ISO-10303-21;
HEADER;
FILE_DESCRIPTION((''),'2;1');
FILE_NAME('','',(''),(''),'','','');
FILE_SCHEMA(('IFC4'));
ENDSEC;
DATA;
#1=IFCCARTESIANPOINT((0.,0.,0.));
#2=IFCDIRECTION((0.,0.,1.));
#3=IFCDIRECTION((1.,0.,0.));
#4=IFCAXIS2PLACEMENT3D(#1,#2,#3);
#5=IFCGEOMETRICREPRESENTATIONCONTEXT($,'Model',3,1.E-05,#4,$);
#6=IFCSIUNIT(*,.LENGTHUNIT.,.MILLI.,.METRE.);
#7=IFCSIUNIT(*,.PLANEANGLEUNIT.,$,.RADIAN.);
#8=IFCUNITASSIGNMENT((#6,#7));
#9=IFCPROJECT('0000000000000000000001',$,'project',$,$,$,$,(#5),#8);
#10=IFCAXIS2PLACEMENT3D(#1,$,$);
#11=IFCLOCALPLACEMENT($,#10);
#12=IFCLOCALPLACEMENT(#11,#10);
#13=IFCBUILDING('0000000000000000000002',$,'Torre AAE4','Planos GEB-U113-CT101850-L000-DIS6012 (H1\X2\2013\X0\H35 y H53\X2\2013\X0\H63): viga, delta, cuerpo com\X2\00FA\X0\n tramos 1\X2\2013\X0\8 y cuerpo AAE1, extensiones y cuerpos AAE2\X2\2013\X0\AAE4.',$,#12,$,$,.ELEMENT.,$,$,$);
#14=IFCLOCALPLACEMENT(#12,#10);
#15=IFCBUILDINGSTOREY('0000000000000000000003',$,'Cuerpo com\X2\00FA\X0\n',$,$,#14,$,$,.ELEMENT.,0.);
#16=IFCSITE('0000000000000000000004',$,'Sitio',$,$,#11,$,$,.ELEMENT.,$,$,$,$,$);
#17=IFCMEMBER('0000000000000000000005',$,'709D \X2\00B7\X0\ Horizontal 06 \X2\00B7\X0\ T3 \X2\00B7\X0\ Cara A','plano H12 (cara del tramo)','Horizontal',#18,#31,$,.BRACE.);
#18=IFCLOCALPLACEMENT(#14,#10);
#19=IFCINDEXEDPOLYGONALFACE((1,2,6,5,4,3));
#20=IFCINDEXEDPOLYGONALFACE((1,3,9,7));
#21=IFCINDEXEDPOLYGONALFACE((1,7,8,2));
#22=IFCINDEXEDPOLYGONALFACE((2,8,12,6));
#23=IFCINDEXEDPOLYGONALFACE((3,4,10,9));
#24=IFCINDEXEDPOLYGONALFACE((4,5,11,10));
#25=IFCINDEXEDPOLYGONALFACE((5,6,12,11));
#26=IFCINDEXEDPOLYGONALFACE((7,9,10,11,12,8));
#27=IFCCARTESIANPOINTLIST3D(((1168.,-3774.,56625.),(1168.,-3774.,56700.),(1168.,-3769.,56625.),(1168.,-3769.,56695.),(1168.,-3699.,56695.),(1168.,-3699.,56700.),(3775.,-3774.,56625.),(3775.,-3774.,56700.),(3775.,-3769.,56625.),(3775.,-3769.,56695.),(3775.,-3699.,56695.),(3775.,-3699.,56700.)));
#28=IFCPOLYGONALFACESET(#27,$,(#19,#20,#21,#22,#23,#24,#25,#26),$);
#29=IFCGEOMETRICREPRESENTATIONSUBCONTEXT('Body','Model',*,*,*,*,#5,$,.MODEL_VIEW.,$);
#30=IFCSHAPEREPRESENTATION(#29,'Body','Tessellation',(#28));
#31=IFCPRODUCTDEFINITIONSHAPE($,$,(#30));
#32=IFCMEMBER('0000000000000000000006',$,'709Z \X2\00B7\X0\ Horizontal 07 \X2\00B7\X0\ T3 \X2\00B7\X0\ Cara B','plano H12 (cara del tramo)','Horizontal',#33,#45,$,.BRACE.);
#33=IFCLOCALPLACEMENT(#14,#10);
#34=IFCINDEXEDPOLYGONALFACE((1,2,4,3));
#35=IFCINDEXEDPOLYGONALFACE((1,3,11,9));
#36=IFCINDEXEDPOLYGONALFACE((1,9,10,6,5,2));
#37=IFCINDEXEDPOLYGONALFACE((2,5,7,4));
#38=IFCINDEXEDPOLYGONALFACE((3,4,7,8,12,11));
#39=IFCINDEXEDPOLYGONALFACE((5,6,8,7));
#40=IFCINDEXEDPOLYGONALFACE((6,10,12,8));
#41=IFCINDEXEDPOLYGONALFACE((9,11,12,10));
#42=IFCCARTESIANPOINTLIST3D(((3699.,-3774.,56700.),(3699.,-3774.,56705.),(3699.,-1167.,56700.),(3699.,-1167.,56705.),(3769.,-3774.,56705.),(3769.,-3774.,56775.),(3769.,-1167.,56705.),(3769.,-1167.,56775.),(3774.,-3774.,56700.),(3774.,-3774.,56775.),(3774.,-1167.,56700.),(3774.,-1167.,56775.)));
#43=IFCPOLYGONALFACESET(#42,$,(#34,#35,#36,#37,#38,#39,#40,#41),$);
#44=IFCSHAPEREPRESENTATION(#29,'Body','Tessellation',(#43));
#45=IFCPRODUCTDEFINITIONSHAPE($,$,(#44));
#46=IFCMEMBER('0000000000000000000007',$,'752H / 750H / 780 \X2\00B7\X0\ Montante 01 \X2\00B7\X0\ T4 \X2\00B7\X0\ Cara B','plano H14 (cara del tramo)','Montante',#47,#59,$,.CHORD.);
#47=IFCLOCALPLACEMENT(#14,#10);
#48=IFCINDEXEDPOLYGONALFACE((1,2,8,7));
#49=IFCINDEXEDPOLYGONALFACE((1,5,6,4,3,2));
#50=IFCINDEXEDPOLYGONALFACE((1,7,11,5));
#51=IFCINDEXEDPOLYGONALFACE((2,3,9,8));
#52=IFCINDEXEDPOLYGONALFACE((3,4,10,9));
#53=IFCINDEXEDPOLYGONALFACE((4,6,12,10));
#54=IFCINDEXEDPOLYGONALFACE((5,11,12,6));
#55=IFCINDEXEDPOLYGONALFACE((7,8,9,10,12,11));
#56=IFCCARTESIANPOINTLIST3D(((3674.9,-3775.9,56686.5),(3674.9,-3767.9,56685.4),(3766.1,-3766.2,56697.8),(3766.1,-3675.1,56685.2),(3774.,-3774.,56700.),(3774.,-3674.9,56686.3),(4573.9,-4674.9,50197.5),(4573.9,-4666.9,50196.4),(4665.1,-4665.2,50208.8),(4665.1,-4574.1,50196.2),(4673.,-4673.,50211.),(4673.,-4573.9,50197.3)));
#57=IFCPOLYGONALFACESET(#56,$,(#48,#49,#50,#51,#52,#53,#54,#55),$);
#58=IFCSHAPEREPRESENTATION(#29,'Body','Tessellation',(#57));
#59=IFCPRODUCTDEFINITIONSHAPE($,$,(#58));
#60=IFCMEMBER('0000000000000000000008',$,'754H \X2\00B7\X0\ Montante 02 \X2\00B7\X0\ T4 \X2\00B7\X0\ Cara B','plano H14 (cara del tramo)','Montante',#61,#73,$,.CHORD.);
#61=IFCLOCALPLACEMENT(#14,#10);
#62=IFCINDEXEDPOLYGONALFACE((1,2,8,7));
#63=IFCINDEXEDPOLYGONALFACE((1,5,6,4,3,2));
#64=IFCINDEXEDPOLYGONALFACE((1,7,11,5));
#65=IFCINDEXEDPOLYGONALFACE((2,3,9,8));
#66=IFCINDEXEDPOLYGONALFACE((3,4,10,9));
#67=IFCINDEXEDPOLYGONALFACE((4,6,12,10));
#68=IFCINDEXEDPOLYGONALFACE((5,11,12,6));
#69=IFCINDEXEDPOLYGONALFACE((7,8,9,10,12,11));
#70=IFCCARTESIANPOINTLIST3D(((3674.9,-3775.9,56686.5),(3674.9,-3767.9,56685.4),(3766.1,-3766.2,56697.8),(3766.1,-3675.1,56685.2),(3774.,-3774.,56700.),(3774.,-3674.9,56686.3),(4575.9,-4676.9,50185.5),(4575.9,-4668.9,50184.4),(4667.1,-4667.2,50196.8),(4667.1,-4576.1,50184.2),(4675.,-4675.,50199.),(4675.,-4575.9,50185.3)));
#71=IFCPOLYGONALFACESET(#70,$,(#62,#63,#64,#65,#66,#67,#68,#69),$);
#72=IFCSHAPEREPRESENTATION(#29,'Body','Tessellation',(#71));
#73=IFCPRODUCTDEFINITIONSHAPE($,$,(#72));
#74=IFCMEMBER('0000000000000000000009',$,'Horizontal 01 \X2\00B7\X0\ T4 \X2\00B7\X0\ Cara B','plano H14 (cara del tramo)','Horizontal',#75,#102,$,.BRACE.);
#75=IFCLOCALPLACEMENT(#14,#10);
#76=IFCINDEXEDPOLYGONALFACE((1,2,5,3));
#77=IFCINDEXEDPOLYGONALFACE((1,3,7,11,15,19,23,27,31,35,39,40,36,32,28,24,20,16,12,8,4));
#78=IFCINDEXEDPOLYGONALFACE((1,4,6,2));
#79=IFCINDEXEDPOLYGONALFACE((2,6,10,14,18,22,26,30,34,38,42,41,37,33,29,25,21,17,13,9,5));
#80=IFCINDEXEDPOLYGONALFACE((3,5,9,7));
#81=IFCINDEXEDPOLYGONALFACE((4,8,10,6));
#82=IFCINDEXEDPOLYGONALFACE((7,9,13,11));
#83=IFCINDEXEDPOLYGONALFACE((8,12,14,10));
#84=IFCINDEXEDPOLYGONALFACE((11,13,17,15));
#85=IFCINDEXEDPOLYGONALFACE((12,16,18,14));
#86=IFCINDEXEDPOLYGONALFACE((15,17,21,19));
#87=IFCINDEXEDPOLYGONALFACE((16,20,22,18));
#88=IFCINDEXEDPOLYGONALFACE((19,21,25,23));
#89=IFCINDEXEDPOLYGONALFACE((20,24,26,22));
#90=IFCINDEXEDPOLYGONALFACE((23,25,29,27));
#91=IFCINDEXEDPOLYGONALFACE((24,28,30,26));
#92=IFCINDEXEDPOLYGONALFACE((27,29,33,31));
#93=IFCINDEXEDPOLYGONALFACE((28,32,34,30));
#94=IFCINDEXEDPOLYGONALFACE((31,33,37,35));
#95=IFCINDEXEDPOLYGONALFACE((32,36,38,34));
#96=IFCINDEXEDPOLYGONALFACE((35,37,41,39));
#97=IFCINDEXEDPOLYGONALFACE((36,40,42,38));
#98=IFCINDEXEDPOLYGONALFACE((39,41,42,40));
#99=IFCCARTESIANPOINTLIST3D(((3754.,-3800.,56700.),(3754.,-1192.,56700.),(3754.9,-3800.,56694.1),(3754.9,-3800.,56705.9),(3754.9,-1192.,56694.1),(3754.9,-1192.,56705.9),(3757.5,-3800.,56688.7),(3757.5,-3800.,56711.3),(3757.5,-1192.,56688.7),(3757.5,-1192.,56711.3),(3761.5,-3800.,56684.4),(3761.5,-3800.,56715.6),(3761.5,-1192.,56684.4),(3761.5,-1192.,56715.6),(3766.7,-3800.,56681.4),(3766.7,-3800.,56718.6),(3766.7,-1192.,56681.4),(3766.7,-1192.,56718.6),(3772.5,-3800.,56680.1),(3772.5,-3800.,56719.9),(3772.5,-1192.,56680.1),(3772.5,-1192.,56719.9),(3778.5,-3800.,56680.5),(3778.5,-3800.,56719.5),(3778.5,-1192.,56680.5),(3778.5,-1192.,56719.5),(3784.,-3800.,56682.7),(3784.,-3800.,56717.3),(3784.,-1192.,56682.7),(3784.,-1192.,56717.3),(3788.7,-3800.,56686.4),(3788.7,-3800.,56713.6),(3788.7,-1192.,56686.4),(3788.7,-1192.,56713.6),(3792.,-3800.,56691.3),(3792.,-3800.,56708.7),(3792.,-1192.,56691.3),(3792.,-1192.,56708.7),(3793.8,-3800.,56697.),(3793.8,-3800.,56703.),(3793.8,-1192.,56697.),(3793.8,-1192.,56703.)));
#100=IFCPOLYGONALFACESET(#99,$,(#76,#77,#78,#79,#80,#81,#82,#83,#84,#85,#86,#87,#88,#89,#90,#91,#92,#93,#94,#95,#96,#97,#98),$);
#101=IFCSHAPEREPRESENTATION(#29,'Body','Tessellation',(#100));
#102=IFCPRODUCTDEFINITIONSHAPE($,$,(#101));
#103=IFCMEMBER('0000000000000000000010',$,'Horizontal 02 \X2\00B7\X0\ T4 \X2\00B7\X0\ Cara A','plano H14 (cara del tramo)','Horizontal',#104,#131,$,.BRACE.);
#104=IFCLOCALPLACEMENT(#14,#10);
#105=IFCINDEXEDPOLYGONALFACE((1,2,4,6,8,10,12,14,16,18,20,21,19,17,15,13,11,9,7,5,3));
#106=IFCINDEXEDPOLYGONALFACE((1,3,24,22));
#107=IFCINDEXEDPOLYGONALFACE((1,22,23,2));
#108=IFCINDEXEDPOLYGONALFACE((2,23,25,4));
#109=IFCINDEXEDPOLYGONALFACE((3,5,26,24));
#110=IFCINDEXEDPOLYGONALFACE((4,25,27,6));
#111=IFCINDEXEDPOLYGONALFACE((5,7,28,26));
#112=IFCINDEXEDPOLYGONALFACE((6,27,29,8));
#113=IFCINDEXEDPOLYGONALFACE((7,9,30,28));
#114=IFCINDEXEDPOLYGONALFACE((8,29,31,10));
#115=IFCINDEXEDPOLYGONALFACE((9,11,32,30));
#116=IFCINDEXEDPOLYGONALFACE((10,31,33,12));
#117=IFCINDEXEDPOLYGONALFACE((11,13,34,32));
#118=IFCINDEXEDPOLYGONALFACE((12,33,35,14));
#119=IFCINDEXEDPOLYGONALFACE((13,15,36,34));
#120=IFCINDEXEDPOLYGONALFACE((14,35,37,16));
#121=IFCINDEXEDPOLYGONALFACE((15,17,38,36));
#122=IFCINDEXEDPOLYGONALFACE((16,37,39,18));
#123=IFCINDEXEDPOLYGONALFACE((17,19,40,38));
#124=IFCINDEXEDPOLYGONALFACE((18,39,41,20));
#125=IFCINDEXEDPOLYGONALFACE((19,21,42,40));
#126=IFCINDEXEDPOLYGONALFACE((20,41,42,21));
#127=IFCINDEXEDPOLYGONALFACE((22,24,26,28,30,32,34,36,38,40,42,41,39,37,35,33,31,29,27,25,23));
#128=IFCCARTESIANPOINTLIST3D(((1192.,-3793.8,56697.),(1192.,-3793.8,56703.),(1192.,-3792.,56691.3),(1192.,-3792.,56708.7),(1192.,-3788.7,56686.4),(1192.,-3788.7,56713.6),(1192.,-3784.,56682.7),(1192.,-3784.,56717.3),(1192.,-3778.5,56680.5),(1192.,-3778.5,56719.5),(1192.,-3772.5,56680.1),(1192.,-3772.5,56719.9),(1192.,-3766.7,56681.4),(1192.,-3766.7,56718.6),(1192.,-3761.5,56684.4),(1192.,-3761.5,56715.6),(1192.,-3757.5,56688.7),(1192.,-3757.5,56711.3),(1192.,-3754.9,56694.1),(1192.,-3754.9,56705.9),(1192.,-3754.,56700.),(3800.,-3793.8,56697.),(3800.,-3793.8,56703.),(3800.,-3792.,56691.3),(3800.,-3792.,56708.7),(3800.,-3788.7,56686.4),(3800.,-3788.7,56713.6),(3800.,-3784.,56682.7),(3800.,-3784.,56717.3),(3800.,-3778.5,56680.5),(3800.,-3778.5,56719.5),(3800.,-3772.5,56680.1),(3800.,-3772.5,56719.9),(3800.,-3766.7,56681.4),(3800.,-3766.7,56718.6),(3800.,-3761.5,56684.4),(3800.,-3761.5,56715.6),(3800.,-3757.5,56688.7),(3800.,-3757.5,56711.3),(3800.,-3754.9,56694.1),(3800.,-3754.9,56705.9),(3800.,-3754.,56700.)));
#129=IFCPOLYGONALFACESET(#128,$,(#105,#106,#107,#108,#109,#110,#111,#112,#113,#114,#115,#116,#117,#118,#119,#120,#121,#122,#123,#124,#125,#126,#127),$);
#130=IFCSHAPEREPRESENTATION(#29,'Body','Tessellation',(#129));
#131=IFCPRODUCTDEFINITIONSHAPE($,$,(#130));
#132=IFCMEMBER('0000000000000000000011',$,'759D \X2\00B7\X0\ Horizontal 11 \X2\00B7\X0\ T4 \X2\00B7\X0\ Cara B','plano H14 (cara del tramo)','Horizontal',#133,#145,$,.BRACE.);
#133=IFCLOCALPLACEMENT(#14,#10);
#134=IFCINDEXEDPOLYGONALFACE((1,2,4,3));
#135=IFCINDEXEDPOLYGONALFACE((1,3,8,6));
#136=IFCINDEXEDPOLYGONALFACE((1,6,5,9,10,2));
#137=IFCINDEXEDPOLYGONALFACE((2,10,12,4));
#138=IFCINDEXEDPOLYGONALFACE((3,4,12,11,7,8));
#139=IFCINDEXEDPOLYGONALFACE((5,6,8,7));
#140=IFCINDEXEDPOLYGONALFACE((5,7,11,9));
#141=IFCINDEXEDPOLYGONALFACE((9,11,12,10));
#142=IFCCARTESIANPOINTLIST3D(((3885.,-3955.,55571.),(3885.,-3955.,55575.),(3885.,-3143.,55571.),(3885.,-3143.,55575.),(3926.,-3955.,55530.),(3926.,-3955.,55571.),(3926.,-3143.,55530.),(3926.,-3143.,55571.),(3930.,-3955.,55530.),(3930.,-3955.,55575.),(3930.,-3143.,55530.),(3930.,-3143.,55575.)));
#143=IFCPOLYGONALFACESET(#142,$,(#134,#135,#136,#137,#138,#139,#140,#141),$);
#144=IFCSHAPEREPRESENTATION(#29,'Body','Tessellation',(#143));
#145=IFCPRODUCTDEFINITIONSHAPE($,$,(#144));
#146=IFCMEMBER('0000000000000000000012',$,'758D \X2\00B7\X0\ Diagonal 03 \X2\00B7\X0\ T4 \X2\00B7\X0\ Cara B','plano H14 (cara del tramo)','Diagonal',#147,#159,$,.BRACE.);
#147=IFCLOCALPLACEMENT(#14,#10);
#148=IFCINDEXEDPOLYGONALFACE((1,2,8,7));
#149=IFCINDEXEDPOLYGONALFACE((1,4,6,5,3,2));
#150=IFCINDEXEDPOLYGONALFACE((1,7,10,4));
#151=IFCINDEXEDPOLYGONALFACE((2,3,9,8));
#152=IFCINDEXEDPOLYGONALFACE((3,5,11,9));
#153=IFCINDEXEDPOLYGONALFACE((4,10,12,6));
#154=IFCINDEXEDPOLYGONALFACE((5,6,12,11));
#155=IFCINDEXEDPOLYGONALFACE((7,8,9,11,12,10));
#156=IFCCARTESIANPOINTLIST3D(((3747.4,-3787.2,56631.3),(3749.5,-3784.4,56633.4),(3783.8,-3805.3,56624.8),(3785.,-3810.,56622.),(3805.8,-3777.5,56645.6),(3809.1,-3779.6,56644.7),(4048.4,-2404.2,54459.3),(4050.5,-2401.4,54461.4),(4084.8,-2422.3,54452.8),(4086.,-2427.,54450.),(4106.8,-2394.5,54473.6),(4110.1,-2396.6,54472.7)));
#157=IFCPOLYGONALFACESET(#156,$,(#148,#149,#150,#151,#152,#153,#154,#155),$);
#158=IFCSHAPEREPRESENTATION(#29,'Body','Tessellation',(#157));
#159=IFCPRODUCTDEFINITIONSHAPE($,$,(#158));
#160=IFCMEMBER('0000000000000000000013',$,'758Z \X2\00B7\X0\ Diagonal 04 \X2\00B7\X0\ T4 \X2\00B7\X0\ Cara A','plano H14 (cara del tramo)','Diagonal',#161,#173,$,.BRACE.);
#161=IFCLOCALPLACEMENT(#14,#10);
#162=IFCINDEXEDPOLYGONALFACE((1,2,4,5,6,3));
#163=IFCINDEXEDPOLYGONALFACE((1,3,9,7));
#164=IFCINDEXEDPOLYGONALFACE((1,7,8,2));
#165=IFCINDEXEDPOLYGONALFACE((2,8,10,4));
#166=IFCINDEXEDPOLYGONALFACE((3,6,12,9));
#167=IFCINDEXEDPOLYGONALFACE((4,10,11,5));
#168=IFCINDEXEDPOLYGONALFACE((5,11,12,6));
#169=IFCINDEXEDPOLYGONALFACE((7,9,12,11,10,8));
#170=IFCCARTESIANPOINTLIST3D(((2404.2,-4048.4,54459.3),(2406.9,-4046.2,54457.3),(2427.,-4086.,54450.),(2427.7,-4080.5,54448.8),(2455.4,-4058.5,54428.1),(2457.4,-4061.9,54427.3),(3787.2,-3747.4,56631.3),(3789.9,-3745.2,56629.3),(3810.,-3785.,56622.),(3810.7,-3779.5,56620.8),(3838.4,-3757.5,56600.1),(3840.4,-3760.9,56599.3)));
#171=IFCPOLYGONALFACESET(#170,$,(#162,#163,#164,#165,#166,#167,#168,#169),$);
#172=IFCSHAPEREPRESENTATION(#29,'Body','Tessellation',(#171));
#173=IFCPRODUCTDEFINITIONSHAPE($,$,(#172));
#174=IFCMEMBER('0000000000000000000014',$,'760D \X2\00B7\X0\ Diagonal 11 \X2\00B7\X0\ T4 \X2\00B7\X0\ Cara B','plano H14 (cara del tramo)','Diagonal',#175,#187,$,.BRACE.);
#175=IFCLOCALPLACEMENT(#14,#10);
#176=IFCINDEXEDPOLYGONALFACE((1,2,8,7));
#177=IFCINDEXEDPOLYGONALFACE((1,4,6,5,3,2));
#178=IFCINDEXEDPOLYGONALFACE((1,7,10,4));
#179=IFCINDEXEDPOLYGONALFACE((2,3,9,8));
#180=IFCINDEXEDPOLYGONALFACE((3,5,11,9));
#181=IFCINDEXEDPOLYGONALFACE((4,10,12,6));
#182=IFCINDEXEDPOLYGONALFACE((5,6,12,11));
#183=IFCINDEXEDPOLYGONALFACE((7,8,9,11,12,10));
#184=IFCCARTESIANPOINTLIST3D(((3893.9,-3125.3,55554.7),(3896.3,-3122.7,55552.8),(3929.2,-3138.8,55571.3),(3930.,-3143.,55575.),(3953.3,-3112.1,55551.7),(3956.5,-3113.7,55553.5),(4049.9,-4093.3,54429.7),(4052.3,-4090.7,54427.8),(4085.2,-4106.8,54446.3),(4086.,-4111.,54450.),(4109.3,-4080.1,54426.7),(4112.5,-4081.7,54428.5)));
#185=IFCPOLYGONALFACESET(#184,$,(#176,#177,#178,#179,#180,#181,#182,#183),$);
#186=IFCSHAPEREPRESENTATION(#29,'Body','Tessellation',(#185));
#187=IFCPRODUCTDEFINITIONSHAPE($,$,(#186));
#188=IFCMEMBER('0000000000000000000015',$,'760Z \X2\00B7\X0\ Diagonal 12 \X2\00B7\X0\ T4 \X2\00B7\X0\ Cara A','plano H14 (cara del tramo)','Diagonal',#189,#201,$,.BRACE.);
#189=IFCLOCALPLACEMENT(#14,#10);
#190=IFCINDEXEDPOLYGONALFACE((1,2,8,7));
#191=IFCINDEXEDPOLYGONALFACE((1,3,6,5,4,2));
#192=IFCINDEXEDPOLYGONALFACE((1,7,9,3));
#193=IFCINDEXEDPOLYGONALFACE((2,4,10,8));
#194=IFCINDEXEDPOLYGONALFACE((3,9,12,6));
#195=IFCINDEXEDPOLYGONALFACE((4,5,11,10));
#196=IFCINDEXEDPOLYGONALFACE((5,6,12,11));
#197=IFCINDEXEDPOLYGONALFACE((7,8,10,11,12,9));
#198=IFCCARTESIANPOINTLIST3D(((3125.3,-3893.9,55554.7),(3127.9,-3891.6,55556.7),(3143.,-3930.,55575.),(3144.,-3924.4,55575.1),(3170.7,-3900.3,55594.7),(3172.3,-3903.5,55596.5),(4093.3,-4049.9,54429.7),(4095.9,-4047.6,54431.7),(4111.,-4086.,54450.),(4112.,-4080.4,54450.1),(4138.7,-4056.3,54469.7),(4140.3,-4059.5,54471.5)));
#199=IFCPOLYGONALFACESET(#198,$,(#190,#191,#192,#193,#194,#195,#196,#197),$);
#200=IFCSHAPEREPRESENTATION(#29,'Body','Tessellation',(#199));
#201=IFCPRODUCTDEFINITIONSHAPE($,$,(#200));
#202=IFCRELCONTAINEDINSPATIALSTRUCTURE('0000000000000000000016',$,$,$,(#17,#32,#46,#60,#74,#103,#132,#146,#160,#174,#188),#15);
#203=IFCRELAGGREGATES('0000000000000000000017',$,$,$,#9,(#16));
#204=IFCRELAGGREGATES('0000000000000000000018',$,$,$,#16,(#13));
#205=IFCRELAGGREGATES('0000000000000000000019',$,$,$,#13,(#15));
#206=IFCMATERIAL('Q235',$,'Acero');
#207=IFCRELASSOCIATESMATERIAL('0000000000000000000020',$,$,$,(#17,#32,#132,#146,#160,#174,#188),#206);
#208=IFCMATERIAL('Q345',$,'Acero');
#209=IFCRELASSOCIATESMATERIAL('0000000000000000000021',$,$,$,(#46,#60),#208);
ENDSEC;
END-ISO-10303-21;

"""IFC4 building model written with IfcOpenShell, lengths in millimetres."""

from ifc_helpers import new_model, si_unit, frame, frame_2d, origin, origin_with_axes, place, context, subcontext, project, spatial, circle, l_section, extrude, material, element, save


model = new_model("IFC4")

# Units and contexts
model_context = context("Model", 3, precision=1e-05, world=origin_with_axes())
body_context = subcontext(model_context, "Body", "Model", "MODEL_VIEW")
ifc_project = project(units=[si_unit("LENGTHUNIT", "METRE", prefix="MILLI"), si_unit("PLANEANGLEUNIT", "RADIAN")], contexts=[model_context])

# Site, building, storey
site_placement = place(None, origin())
site = spatial("IfcSite", under=ifc_project, at=site_placement, Name="Sitio", CompositionType="ELEMENT")
building_placement = place(site_placement, origin())
building = spatial("IfcBuilding", under=site, at=building_placement, Name="Torre AAE4", Description="Planos GEB-U113-CT101850-L000-DIS6012 (H1–H35 y H53–H63): viga, delta, cuerpo común tramos 1–8 y cuerpo AAE1, extensiones y cuerpos AAE2–AAE4.", CompositionType="ELEMENT")
storey_placement = place(building_placement, origin())
storey = spatial("IfcBuildingStorey", under=building, at=storey_placement, Name="Cuerpo común", CompositionType="ELEMENT", Elevation=0.0)

# Members
ifc_material_1 = material(Name="Q235", Category="Acero")
for number, where, z_axis, x_axis, name in (
    (1, (3775.0, -3774.0, 56700.0), (-1.0, 0.0, 0.0), (0.0, 1.0, 0.0), "709D · Horizontal 06 · T3 · Cara A"),
    (2, (3774.0, -3774.0, 56700.0), (0.0, 1.0, 0.0), (-1.0, 0.0, 0.0), "709Z · Horizontal 07 · T3 · Cara B"),
):
    element("IfcMember", number, at=place(storey_placement, frame(where, z_axis=z_axis, x_axis=x_axis)), inside=storey, material=ifc_material_1, Name=name, Description="plano H12 (cara del tramo)", ObjectType="Horizontal", PredefinedType="BRACE", context=body_context, shape_type="SweptSolid", body=[
        extrude(l_section(Depth=75.0, Width=75.0, Thickness=5.0, at=frame_2d((37.5, 37.5))), None, (0.0, 0.0, 1.0), 2607.0),
    ])
ifc_material_2 = material(Name="Q345", Category="Acero")
member_1_placement = place(storey_placement, frame((3774.0, -3774.0, 56700.0), z_axis=(0.135957, -0.135957, -0.981342), x_axis=(-0.990715, -0.018658, -0.134671)))
element("IfcMember", 3, at=member_1_placement, inside=storey, material=ifc_material_2, Name="752H / 750H / 780 · Montante 01 · T4 · Cara B", Description="plano H14 (cara del tramo)", ObjectType="Montante", PredefinedType="CHORD", context=body_context, shape_type="SweptSolid", body=[
    extrude(l_section(Depth=100.0, Width=100.0, Thickness=8.0, at=frame_2d((50.0, 50.0))), None, (0.0, 0.0, 1.0), 6612.4),
])
member_2_placement = place(storey_placement, frame((3774.0, -3774.0, 56700.0), z_axis=(0.136006, -0.136006, -0.981328), x_axis=(-0.990708, -0.018671, -0.134719)))
element("IfcMember", 4, at=member_2_placement, inside=storey, material=ifc_material_2, Name="754H · Montante 02 · T4 · Cara B", Description="plano H14 (cara del tramo)", ObjectType="Montante", PredefinedType="CHORD", context=body_context, shape_type="SweptSolid", body=[
    extrude(l_section(Depth=100.0, Width=100.0, Thickness=8.0, at=frame_2d((50.0, 50.0))), None, (0.0, 0.0, 1.0), 6624.7),
])
for number, where, z_axis, x_axis, name in (
    (5, (3774.0, -3800.0, 56700.0), (0.0, 1.0, 0.0), (-1.0, 0.0, 0.0), "Horizontal 01 · T4 · Cara B"),
    (6, (3800.0, -3774.0, 56700.0), (-1.0, 0.0, 0.0), (0.0, 1.0, 0.0), "Horizontal 02 · T4 · Cara A"),
):
    element("IfcMember", number, at=place(storey_placement, frame(where, z_axis=z_axis, x_axis=x_axis)), inside=storey, Name=name, Description="plano H14 (cara del tramo)", ObjectType="Horizontal", PredefinedType="BRACE", context=body_context, shape_type="SweptSolid", body=[
        extrude(circle(Radius=20.0), None, (0.0, 0.0, 1.0), 2608.0),
    ])
member_3_placement = place(storey_placement, frame((3930.0, -3143.0, 55575.0), z_axis=(0.0, -1.0, 0.0), x_axis=(-1.0, 0.0, 0.0)))
element("IfcMember", 7, at=member_3_placement, inside=storey, material=ifc_material_1, Name="759D · Horizontal 11 · T4 · Cara B", Description="plano H14 (cara del tramo)", ObjectType="Horizontal", PredefinedType="BRACE", context=body_context, shape_type="SweptSolid", body=[
    extrude(l_section(Depth=45.0, Width=45.0, Thickness=4.0, at=frame_2d((22.5, 22.5))), None, (0.0, 0.0, 1.0), 812.0),
])
for number, where, z_axis, x_axis, name in (
    (8, (3785.0, -3810.0, 56622.0), (0.116106, 0.533469, -0.837813), (-0.836171, 0.507736, 0.207418), "758D · Diagonal 03 · T4 · Cara B"),
    (9, (3810.0, -3785.0, 56622.0), (-0.533469, -0.116106, -0.837813), (-0.507736, 0.836171, 0.207418), "758Z · Diagonal 04 · T4 · Cara A"),
):
    element("IfcMember", number, at=place(storey_placement, frame(where, z_axis=z_axis, x_axis=x_axis)), inside=storey, material=ifc_material_1, Name=name, Description="plano H14 (cara del tramo)", ObjectType="Diagonal", PredefinedType="BRACE", context=body_context, shape_type="SweptSolid", body=[
        extrude(l_section(Depth=45.0, Width=45.0, Thickness=4.0, at=frame_2d((22.5, 22.5))), None, (0.0, 0.0, 1.0), 2592.5),
    ])
for number, where, z_axis, x_axis, name in (
    (10, (3930.0, -3143.0, 55575.0), (0.104536, -0.648659, -0.753866), (-0.801211, 0.394141, -0.450238), "760D · Diagonal 11 · T4 · Cara B"),
    (11, (3143.0, -3930.0, 55575.0), (0.648659, -0.104536, -0.753866), (-0.394141, 0.801211, -0.450238), "760Z · Diagonal 12 · T4 · Cara A"),
):
    element("IfcMember", number, at=place(storey_placement, frame(where, z_axis=z_axis, x_axis=x_axis)), inside=storey, material=ifc_material_1, Name=name, Description="plano H14 (cara del tramo)", ObjectType="Diagonal", PredefinedType="BRACE", context=body_context, shape_type="SweptSolid", body=[
        extrude(l_section(Depth=45.0, Width=45.0, Thickness=4.0, at=frame_2d((22.5, 22.5))), None, (0.0, 0.0, 1.0), 1492.3),
    ])

save(model, "model.ifc")
